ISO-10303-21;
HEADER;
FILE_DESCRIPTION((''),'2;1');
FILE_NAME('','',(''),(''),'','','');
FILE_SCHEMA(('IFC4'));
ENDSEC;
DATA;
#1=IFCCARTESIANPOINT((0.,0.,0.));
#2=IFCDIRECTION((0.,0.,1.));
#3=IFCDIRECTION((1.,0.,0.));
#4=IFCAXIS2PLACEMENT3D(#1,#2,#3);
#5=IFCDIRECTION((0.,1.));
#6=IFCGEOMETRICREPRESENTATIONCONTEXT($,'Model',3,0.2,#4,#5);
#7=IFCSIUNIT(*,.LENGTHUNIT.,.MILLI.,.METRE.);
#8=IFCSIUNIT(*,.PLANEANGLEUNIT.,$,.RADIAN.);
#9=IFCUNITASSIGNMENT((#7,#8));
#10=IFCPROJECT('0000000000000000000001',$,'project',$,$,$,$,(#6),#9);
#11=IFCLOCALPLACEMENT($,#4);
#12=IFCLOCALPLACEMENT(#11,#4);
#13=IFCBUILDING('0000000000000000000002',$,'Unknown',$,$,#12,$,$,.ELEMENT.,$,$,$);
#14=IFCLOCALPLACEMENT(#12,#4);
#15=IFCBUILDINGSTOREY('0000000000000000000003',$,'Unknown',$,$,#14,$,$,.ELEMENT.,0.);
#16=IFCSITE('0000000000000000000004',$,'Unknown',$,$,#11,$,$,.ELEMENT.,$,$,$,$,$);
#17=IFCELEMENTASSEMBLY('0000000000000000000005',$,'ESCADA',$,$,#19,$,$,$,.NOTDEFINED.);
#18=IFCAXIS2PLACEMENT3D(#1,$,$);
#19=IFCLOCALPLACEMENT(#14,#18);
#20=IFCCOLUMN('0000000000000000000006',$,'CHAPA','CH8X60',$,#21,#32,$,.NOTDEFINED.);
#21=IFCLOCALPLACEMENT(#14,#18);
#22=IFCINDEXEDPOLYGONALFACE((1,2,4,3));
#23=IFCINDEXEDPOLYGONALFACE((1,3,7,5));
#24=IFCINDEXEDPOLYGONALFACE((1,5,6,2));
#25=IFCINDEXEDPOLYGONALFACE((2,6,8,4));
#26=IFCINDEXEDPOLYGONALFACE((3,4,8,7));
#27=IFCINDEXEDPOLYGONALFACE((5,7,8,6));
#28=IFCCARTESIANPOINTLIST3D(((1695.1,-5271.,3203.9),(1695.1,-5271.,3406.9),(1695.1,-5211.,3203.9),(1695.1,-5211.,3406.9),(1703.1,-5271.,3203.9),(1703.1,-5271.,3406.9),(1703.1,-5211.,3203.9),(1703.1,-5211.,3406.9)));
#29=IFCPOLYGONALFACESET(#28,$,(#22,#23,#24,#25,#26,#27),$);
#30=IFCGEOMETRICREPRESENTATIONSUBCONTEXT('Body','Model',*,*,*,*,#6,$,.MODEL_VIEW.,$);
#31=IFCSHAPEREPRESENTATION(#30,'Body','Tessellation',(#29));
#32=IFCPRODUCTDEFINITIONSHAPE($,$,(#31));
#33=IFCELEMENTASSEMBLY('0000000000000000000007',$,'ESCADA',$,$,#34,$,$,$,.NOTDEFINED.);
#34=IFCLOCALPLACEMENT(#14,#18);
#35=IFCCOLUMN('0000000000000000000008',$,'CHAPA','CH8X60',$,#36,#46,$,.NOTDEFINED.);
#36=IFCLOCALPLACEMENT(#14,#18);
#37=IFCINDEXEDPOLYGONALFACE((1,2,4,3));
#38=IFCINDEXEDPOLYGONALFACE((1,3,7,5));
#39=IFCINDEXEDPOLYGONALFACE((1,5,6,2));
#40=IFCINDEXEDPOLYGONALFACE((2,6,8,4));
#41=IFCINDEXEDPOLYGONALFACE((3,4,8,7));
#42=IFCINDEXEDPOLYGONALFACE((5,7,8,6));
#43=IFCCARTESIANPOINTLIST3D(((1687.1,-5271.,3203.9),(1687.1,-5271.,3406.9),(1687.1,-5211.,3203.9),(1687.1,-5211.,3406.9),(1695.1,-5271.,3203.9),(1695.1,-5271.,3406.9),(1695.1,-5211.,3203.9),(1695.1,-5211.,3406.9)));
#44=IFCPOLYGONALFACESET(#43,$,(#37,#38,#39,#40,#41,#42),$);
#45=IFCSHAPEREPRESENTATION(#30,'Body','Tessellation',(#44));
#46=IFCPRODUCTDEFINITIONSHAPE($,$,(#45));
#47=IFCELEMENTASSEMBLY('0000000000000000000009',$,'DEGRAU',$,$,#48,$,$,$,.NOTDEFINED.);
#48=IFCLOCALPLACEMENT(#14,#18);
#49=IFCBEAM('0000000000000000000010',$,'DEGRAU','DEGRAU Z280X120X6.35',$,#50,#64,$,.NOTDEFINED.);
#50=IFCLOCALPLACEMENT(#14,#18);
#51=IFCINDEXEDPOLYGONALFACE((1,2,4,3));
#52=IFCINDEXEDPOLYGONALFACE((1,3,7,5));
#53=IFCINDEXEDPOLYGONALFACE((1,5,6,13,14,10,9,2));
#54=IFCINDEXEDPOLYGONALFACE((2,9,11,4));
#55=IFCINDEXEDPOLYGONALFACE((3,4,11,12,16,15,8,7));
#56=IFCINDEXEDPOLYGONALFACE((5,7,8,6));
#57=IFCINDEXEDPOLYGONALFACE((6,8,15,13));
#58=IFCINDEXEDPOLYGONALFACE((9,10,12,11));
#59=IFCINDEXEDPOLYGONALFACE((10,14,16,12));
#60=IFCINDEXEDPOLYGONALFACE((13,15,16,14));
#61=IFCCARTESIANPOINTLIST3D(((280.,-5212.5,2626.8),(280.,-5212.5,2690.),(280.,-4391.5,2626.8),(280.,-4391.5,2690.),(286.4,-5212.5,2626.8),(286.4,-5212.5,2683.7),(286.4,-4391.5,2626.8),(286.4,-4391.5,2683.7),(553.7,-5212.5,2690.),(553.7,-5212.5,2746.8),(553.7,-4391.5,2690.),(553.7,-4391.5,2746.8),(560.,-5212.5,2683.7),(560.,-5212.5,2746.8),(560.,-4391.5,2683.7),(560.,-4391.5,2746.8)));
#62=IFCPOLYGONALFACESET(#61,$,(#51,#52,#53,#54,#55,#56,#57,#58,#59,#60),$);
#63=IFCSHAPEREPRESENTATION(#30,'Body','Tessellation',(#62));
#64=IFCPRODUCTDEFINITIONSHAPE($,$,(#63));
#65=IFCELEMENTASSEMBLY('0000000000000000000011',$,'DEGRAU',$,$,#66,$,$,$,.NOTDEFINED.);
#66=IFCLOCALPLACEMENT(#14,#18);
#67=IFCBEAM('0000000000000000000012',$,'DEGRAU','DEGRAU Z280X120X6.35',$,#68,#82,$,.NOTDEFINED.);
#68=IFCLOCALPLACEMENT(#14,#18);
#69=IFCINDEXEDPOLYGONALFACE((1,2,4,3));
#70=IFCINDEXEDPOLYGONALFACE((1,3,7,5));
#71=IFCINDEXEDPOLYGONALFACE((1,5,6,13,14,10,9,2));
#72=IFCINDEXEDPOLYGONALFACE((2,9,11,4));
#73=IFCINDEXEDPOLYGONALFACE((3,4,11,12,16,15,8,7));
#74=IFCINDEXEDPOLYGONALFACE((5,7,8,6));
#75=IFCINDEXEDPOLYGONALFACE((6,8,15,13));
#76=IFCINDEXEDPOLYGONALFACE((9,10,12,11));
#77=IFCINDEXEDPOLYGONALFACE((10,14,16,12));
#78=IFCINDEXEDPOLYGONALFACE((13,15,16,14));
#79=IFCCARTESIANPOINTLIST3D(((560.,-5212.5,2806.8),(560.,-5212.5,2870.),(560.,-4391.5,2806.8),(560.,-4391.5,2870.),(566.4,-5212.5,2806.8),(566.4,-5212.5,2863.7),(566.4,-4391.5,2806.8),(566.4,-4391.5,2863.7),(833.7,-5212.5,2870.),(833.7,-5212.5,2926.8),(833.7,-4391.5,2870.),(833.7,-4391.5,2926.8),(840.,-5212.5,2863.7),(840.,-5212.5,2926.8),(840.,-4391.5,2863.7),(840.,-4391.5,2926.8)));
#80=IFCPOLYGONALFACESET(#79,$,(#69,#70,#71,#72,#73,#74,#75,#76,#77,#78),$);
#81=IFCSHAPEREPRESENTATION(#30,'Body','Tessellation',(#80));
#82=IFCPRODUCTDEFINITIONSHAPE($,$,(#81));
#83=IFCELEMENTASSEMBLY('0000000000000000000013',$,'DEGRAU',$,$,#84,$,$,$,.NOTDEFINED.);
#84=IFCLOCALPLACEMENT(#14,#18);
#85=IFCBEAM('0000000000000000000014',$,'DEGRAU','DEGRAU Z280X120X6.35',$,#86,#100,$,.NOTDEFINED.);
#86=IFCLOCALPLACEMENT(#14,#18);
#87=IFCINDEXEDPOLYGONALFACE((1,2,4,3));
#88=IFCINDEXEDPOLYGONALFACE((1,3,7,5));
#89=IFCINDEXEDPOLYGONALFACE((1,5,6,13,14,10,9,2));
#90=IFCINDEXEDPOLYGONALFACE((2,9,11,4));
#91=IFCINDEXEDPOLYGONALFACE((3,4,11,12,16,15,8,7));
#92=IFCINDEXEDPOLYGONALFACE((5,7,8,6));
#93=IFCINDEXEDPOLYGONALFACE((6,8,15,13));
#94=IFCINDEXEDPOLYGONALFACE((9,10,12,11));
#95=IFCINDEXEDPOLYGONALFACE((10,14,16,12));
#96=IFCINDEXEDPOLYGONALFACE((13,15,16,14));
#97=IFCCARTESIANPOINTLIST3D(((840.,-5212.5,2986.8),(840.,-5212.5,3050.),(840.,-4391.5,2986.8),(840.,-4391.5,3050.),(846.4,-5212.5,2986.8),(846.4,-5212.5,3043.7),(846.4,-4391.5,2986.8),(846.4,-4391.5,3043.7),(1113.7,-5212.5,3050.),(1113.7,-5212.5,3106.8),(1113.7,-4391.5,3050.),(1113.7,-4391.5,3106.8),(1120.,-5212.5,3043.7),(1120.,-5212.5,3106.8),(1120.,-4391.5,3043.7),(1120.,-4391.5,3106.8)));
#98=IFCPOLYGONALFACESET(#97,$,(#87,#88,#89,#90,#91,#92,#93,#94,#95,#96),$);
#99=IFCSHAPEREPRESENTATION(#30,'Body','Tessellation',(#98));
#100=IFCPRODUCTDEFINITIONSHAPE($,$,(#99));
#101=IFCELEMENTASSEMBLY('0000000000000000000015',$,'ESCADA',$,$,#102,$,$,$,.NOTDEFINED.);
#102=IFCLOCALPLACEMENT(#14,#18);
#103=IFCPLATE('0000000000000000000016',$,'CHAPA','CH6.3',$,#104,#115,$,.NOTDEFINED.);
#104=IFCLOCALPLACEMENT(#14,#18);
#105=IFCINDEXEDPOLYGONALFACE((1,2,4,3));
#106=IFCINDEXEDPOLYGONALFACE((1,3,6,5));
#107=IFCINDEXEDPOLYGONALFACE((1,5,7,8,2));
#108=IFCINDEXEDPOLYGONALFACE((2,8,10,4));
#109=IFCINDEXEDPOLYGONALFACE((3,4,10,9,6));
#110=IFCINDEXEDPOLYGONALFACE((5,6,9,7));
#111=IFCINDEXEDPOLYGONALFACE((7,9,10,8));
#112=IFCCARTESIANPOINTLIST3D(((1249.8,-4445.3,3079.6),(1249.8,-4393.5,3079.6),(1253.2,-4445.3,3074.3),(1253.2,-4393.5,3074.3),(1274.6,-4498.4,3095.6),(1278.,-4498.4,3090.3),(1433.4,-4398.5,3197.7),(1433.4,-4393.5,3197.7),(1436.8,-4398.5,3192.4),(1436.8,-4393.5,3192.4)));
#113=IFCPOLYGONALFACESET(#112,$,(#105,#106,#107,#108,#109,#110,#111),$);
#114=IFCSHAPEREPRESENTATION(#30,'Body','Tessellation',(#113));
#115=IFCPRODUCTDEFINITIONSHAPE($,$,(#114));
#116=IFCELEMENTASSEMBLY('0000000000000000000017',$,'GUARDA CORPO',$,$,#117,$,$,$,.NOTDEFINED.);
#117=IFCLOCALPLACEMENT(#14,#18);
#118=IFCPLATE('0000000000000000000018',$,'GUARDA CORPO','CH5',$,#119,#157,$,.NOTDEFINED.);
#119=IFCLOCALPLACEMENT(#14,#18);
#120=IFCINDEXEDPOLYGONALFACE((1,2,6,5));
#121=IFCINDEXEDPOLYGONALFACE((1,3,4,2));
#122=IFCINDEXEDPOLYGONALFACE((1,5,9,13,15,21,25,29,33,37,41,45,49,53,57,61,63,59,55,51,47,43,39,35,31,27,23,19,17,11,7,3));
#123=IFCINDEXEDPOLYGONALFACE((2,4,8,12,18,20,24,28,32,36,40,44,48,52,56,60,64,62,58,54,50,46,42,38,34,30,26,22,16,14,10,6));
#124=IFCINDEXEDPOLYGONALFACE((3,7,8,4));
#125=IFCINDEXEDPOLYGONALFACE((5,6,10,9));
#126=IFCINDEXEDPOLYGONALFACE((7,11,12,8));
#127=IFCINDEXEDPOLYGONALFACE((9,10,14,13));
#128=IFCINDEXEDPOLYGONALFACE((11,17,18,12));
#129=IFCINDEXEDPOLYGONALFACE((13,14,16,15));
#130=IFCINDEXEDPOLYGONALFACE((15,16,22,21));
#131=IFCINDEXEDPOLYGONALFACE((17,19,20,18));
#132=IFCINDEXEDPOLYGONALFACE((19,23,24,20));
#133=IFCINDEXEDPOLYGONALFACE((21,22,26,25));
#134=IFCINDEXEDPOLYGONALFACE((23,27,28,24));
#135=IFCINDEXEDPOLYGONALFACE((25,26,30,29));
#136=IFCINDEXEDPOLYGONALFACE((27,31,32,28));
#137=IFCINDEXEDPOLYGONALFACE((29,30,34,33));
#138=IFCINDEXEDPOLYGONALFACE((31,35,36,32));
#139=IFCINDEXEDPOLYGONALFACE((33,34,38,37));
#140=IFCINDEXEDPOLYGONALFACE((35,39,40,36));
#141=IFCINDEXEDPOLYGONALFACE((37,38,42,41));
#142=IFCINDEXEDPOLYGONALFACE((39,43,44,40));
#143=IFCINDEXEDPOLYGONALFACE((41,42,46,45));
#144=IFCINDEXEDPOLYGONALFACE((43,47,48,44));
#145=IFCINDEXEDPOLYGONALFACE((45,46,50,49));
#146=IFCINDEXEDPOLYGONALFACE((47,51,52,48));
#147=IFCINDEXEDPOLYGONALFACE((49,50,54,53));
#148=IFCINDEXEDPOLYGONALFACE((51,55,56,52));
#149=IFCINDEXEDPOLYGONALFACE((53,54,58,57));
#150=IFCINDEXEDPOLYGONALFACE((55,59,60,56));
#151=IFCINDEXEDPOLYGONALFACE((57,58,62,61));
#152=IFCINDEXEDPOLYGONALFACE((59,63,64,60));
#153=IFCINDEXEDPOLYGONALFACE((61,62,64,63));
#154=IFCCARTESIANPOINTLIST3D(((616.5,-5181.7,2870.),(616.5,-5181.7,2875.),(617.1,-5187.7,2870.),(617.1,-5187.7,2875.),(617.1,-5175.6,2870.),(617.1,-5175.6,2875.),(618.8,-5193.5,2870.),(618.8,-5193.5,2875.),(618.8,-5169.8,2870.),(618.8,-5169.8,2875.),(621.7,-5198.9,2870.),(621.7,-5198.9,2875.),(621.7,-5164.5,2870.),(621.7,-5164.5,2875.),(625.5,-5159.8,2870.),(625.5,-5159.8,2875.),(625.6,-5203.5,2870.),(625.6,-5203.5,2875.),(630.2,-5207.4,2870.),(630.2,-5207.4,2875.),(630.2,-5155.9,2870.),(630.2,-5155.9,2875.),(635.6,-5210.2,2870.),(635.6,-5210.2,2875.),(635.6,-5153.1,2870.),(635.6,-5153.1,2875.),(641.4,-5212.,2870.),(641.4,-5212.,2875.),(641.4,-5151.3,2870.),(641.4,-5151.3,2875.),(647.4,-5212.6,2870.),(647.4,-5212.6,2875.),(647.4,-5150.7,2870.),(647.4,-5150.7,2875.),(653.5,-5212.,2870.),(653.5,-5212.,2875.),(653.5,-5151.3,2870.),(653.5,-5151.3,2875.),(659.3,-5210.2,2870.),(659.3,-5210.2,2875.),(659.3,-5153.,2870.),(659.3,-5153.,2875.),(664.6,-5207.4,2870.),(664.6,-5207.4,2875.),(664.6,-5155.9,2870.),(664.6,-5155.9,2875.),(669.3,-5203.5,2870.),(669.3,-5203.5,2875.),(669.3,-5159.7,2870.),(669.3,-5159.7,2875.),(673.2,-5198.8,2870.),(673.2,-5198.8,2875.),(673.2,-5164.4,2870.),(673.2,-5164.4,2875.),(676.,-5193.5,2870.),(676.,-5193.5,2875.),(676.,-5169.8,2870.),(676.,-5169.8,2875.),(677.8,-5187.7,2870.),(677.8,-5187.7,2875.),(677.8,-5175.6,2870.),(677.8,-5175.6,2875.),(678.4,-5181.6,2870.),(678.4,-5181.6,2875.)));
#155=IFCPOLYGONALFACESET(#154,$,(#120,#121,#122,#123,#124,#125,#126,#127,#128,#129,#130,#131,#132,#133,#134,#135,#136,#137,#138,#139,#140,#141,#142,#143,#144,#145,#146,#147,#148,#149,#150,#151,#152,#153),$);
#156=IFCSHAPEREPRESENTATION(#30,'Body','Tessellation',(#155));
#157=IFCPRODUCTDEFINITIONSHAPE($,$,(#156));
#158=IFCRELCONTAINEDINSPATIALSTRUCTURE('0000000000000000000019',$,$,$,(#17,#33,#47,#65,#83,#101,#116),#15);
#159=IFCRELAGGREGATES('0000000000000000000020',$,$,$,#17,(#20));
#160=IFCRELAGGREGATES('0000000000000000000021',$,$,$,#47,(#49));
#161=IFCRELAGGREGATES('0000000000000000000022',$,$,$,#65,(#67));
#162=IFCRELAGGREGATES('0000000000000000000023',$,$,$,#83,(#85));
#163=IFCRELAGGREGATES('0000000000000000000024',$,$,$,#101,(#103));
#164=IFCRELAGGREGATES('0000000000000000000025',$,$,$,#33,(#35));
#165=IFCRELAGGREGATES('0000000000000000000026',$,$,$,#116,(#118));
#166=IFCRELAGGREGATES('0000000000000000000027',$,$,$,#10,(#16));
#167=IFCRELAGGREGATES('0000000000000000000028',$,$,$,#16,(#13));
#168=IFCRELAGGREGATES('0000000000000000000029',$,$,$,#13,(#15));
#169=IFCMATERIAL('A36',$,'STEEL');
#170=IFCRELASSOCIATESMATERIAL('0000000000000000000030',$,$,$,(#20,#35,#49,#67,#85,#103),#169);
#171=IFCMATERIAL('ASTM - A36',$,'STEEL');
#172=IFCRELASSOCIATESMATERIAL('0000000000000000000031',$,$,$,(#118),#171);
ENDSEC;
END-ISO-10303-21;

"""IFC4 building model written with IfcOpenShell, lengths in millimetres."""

from ifc_helpers import new_model, si_unit, direction, frame, origin_with_axes, place, context, subcontext, project, spatial, line, indexed_curve, outline, extrude, material, element, aggregate, save


model = new_model("IFC4")

# Units and contexts
model_context = context("Model", 3, precision=0.2, world=origin_with_axes(), true_north=direction((0.0, 1.0)))
body_context = subcontext(model_context, "Body", "Model", "MODEL_VIEW")
ifc_project = project(units=[si_unit("LENGTHUNIT", "METRE", prefix="MILLI"), si_unit("PLANEANGLEUNIT", "RADIAN")], contexts=[model_context])

# Site, building, storey
site_placement = place(None, origin_with_axes())
site = spatial("IfcSite", under=ifc_project, at=site_placement, Name="Unknown", CompositionType="ELEMENT")
building_placement = place(site_placement, origin_with_axes())
building = spatial("IfcBuilding", under=site, at=building_placement, Name="Unknown", CompositionType="ELEMENT")
storey_placement = place(building_placement, origin_with_axes())
storey = spatial("IfcBuildingStorey", under=building, at=storey_placement, Name="Unknown", CompositionType="ELEMENT", Elevation=0.0)

# Element assemblies, columns
assembly_1_placement = place(storey_placement, frame((1695.1, -4365.0, 3305.4), z_axis=(0.0, 1.0, 0.0), x_axis=(1.0, 0.0, 0.0)))
assembly_1 = element("IfcElementAssembly", 1, at=assembly_1_placement, inside=storey, Name="ESCADA", PredefinedType="NOTDEFINED")
ifc_material_1 = material(Name="A36", Category="STEEL")
column_1_placement = place(assembly_1_placement, frame((4.0, 101.5, -876.1), z_axis=(1.0, 0.0, 0.0), x_axis=(0.0, -1.0, 0.0)))
column_1 = element("IfcColumn", 2, at=column_1_placement, material=ifc_material_1, Name="CHAPA", Description="CH8X60", PredefinedType="NOTDEFINED", context=body_context, shape_type="SolidModel", body=[
    extrude(outline(indexed_curve([(-4.0, -30.0), (4.0, -30.0), (4.0, 30.0), (-4.0, 30.0)], segments=[line(1, 2, 3, 4, 1)])), frame((0.0, 0.0, 0.0), z_axis=(-1.0, 0.0, 0.0), x_axis=(0.0, 0.0, 1.0)), (0.0, 0.0, -1.0), 203.0),
])
assembly_2_placement = place(storey_placement, frame((1426.3, -5241.0, 3305.4), z_axis=(0.0, -1.0, 0.0), x_axis=(1.0, 0.0, 0.0)))
assembly_2 = element("IfcElementAssembly", 3, at=assembly_2_placement, inside=storey, Name="ESCADA", PredefinedType="NOTDEFINED")
column_2_placement = place(assembly_2_placement, frame((264.8, -101.5, 0.0), z_axis=(1.0, 0.0, 0.0), x_axis=(0.0, 1.0, 0.0)))
column_2 = element("IfcColumn", 4, at=column_2_placement, material=ifc_material_1, Name="CHAPA", Description="CH8X60", PredefinedType="NOTDEFINED", context=body_context, shape_type="SolidModel", body=[
    extrude(outline(indexed_curve([(-4.0, -30.0), (4.0, -30.0), (4.0, 30.0), (-4.0, 30.0)], segments=[line(1, 2, 3, 4, 1)])), frame((0.0, 0.0, 0.0), z_axis=(-1.0, 0.0, 0.0), x_axis=(0.0, 0.0, 1.0)), (0.0, 0.0, -1.0), 203.0),
])

# Element assemblies, beams
assembly_3_placement = place(storey_placement, frame((420.0, -5212.5, 2686.8), z_axis=(0.0, 0.0, -1.0), x_axis=(0.0, 1.0, 0.0)))
assembly_3 = element("IfcElementAssembly", 5, at=assembly_3_placement, inside=storey, Name="DEGRAU", PredefinedType="NOTDEFINED")
beam_1_placement = place(assembly_3_placement, origin_with_axes())
beam_1 = element("IfcBeam", 6, at=beam_1_placement, material=ifc_material_1, Name="DEGRAU", Description="DEGRAU Z280X120X6.35", PredefinedType="NOTDEFINED", context=body_context, shape_type="SolidModel", body=[
    extrude(outline(indexed_curve([(-3.2, -140.0), (60.0, -140.0), (60.0, -133.7), (3.2, -133.7), (3.2, 140.0), (-60.0, 140.0), (-60.0, 133.7), (-3.2, 133.7)], segments=[line(1, 2, 3, 4, 5, 6, 7, 8, 1)])), frame((0.0, 0.0, 0.0), z_axis=(-1.0, 0.0, 0.0), x_axis=(0.0, 0.0, 1.0)), (0.0, 0.0, -1.0), 821.0),
])
assembly_4_placement = place(storey_placement, frame((700.0, -5212.5, 2866.8), z_axis=(0.0, 0.0, -1.0), x_axis=(0.0, 1.0, 0.0)))
assembly_4 = element("IfcElementAssembly", 7, at=assembly_4_placement, inside=storey, Name="DEGRAU", PredefinedType="NOTDEFINED")
beam_2_placement = place(assembly_4_placement, origin_with_axes())
beam_2 = element("IfcBeam", 8, at=beam_2_placement, material=ifc_material_1, Name="DEGRAU", Description="DEGRAU Z280X120X6.35", PredefinedType="NOTDEFINED", context=body_context, shape_type="SolidModel", body=[
    extrude(outline(indexed_curve([(-3.2, -140.0), (60.0, -140.0), (60.0, -133.7), (3.2, -133.7), (3.2, 140.0), (-60.0, 140.0), (-60.0, 133.7), (-3.2, 133.7)], segments=[line(1, 2, 3, 4, 5, 6, 7, 8, 1)])), frame((0.0, 0.0, 0.0), z_axis=(-1.0, 0.0, 0.0), x_axis=(0.0, 0.0, 1.0)), (0.0, 0.0, -1.0), 821.0),
])
assembly_5_placement = place(storey_placement, frame((980.0, -5212.5, 3046.8), z_axis=(0.0, 0.0, -1.0), x_axis=(0.0, 1.0, 0.0)))
assembly_5 = element("IfcElementAssembly", 9, at=assembly_5_placement, inside=storey, Name="DEGRAU", PredefinedType="NOTDEFINED")
beam_3_placement = place(assembly_5_placement, origin_with_axes())
beam_3 = element("IfcBeam", 10, at=beam_3_placement, material=ifc_material_1, Name="DEGRAU", Description="DEGRAU Z280X120X6.35", PredefinedType="NOTDEFINED", context=body_context, shape_type="SolidModel", body=[
    extrude(outline(indexed_curve([(-3.2, -140.0), (60.0, -140.0), (60.0, -133.7), (3.2, -133.7), (3.2, 140.0), (-60.0, 140.0), (-60.0, 133.7), (-3.2, 133.7)], segments=[line(1, 2, 3, 4, 5, 6, 7, 8, 1)])), frame((0.0, 0.0, 0.0), z_axis=(-1.0, 0.0, 0.0), x_axis=(0.0, 0.0, 1.0)), (0.0, 0.0, -1.0), 821.0),
])

# Element assemblies, plates
assembly_6_placement = place(storey_placement, frame((1395.1, -4365.0, 3305.4), z_axis=(0.001514, 0.999999, 0.0), x_axis=(0.999999, -0.001514, 0.0)))
assembly_6 = element("IfcElementAssembly", 11, at=assembly_6_placement, inside=storey, Name="ESCADA", PredefinedType="NOTDEFINED")
plate_1_placement = place(assembly_6_placement, frame((40.0, 110.3, -28.4), z_axis=(-0.540758, -0.841178, -0.000818), x_axis=(-0.841177, 0.540759, -0.001273)))
plate_1 = element("IfcPlate", 12, at=plate_1_placement, material=ifc_material_1, Name="CHAPA", Description="CH6.3", PredefinedType="NOTDEFINED", context=body_context, shape_type="SolidModel", body=[
    extrude(outline(indexed_curve([(0.0, 0.0), (218.3, 0.0), (218.3, 51.9), (188.8, 105.0), (0.0, 5.0)], segments=[line(1, 2, 3, 4, 5, 1)])), frame((0.0, 0.0, 3.1), z_axis=(0.0, 0.0, 1.0), x_axis=(1.0, 0.0, 0.0)), (0.0, 0.0, -1.0), 6.3),
])
assembly_7_placement = place(storey_placement, frame((647.5, -5181.6, 2875.0), z_axis=(-0.000512, 1.0, -0.000003), x_axis=(0.000003, 0.000003, 1.0)))
assembly_7 = element("IfcElementAssembly", 13, at=assembly_7_placement, inside=storey, Name="GUARDA CORPO", PredefinedType="NOTDEFINED")
ifc_material_2 = material(Name="ASTM - A36", Category="STEEL")
plate_2_placement = place(assembly_7_placement, frame((-2.5, 30.2, 6.0), z_axis=(1.0, 0.0, 0.0), x_axis=(0.0, -0.290285, 0.95694)))
plate_2 = element("IfcPlate", 14, at=plate_2_placement, material=ifc_material_2, Name="GUARDA CORPO", Description="CH5", PredefinedType="NOTDEFINED", context=body_context, shape_type="SolidModel", body=[
    extrude(outline(indexed_curve([(0.0, 0.0), (6.1, 0.0), (12.0, 1.2), (17.6, 3.5), (22.7, 6.9), (27.0, 11.2), (30.3, 16.2), (32.7, 21.8), (33.8, 27.8), (33.8, 33.8), (32.7, 39.8), (30.3, 45.4), (27.0, 50.4), (22.7, 54.7), (17.6, 58.1), (12.0, 60.4), (6.1, 61.6), (0.0, 61.6), (-6.0, 60.4), (-11.6, 58.1), (-16.6, 54.7), (-20.9, 50.4), (-24.3, 45.4), (-26.6, 39.8), (-27.8, 33.8), (-27.8, 27.8), (-26.6, 21.8), (-24.3, 16.2), (-20.9, 11.2), (-16.6, 6.9), (-11.6, 3.5), (-6.0, 1.2)], segments=[line(1, 2, 3, 4, 5, 6, 7, 8, 9, 10, 11, 12, 13, 14, 15, 16, 17, 18, 19, 20, 21, 22, 23, 24, 25, 26, 27, 28, 29, 30, 31, 32, 1)])), frame((0.0, 0.0, 2.5), z_axis=(0.0, 0.0, 1.0), x_axis=(1.0, 0.0, 0.0)), (0.0, 0.0, -1.0), 5.0),
])

aggregate(assembly_1, [column_1])

aggregate(assembly_3, [beam_1])
aggregate(assembly_4, [beam_2])
aggregate(assembly_5, [beam_3])
aggregate(assembly_6, [plate_1])
aggregate(assembly_2, [column_2])
aggregate(assembly_7, [plate_2])

save(model, "model.ifc")
